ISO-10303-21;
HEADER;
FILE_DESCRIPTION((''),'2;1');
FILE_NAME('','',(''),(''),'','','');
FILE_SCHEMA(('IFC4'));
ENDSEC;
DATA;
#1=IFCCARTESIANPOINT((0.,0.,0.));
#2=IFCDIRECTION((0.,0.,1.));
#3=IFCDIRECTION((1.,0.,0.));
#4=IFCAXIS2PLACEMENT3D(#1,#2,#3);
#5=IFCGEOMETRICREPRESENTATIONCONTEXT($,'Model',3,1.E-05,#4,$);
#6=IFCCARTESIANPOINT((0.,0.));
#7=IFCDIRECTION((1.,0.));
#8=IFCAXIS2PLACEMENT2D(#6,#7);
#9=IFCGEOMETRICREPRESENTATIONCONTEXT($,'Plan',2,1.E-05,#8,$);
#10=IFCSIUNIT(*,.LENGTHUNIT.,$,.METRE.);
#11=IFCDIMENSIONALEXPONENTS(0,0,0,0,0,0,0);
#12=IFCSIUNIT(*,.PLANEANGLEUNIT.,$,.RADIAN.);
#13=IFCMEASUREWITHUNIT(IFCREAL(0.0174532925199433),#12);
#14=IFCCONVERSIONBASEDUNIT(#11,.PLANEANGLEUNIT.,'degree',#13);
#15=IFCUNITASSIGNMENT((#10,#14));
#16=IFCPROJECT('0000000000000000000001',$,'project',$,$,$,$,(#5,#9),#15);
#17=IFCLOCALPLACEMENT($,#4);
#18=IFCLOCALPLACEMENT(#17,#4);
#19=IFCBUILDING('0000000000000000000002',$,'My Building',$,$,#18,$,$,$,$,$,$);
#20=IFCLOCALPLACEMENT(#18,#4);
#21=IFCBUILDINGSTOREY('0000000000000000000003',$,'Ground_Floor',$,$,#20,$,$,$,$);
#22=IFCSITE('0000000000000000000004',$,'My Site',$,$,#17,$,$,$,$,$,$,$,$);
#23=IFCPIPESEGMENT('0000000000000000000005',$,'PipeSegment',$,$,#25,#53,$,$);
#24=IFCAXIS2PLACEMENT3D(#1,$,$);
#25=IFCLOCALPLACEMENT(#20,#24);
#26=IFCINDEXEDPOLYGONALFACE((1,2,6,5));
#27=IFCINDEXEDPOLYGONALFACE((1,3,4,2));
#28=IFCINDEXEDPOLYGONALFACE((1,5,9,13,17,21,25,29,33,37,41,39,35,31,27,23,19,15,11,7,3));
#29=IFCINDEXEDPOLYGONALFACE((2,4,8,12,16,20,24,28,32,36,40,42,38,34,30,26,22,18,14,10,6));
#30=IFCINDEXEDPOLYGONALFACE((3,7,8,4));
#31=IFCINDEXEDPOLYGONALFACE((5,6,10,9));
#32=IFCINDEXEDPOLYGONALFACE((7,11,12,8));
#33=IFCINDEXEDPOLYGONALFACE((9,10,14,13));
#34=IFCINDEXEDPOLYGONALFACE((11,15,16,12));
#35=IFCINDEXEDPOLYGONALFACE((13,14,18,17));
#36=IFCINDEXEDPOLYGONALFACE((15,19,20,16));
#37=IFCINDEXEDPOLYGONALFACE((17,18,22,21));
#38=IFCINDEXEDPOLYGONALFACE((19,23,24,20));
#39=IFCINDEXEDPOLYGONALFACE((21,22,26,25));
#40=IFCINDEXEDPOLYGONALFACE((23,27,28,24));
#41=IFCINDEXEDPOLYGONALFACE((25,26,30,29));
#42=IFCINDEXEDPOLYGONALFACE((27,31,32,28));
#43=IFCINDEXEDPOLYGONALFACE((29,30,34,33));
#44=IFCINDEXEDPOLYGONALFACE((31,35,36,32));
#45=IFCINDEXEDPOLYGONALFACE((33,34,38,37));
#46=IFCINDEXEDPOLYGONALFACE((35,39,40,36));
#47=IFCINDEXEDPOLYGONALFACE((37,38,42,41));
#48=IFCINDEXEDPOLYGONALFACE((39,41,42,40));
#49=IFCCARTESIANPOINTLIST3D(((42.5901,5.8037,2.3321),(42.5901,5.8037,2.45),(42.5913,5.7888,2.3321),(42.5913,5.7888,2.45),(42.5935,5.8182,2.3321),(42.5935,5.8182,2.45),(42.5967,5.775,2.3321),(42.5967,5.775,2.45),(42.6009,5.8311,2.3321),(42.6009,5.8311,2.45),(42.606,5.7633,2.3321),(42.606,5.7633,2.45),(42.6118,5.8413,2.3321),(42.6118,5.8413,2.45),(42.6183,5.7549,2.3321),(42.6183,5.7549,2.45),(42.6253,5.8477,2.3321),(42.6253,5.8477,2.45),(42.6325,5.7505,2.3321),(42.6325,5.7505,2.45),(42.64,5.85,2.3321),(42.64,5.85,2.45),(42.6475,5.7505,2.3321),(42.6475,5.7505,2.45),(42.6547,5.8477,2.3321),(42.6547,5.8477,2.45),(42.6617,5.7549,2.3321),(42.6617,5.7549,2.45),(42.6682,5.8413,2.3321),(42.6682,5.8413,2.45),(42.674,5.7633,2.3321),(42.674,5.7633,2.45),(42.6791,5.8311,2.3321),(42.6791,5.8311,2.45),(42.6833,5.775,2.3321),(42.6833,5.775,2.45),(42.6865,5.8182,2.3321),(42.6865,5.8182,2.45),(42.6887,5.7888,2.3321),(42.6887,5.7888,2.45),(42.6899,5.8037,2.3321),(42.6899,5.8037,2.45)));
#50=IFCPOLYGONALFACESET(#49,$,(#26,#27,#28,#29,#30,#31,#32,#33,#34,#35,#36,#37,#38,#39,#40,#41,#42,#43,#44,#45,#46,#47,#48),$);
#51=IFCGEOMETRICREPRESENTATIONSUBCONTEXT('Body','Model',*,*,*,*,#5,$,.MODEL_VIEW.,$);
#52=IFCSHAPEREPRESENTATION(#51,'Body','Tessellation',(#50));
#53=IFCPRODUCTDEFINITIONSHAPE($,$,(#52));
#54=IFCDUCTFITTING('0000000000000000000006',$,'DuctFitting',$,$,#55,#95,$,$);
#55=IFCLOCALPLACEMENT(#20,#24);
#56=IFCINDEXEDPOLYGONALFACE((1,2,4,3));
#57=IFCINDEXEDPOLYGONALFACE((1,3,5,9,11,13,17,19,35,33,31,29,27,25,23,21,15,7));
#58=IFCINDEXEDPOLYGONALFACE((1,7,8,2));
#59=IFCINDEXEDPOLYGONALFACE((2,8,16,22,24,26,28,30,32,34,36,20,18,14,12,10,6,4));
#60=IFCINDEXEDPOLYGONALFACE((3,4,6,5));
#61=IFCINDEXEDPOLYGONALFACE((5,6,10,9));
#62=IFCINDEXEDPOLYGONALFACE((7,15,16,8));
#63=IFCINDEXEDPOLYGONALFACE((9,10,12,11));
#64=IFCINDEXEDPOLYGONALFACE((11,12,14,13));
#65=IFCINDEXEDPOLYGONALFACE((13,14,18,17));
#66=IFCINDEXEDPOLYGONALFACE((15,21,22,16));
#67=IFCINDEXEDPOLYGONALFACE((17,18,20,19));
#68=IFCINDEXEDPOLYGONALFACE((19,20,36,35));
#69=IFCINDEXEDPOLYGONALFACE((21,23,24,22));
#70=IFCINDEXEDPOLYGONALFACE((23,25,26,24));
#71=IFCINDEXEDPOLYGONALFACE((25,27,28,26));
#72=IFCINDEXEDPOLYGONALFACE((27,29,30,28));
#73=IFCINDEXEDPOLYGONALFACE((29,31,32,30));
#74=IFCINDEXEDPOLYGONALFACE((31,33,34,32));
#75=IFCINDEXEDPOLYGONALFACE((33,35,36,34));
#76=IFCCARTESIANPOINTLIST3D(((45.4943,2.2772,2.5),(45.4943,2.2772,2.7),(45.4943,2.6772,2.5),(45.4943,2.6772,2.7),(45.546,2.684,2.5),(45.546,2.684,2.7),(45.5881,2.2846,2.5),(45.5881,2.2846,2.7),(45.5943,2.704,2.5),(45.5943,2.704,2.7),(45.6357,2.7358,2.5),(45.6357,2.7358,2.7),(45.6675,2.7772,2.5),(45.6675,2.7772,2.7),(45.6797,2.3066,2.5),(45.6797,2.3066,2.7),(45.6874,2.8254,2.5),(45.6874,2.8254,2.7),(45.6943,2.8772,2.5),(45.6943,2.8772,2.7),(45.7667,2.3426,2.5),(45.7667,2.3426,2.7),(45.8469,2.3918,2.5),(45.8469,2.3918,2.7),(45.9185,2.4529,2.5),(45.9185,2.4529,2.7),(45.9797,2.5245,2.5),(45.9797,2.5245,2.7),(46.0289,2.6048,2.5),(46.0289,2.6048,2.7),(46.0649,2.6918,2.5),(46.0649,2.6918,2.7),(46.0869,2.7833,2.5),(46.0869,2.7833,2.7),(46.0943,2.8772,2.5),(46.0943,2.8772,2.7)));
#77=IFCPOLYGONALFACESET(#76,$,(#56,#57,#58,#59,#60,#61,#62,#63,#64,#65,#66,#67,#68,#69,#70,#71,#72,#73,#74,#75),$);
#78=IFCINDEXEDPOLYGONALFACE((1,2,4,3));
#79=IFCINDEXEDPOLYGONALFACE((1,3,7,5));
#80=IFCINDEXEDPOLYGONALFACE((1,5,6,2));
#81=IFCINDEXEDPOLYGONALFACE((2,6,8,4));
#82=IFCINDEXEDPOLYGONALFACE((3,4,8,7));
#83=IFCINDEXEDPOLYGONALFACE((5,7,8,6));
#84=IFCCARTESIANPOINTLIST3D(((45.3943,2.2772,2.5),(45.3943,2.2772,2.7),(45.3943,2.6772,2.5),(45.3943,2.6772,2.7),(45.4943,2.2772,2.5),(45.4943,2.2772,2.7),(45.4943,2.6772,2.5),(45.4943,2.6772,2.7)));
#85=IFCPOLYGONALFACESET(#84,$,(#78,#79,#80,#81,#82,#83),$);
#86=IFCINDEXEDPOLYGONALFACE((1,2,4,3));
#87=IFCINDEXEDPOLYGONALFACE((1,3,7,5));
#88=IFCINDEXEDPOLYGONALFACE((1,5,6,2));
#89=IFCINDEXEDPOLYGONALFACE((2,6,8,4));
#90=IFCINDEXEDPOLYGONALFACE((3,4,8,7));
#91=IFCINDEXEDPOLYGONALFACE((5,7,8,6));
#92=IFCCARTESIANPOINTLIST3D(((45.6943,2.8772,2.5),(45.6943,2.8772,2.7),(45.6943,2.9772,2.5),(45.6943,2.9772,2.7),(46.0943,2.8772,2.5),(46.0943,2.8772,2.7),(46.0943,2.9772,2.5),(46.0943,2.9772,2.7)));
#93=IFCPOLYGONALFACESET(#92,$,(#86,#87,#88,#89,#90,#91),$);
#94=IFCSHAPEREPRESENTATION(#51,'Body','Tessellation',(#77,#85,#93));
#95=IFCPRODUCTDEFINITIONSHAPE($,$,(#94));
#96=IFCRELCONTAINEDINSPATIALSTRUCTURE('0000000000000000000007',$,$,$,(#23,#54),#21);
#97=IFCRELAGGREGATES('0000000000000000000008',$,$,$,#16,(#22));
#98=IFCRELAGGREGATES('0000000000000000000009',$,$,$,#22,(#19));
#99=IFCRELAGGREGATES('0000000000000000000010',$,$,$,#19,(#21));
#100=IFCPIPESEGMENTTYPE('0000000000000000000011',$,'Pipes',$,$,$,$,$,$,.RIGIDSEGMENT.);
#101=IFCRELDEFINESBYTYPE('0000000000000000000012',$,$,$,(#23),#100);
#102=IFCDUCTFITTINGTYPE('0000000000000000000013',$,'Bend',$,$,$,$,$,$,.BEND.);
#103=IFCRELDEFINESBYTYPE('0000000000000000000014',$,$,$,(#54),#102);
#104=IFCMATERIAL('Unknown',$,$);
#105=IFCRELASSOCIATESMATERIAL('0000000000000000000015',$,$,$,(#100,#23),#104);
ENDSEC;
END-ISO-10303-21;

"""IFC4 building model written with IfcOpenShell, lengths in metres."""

from ifc_helpers import new_model, entity, si_unit, converted_unit, frame, origin_with_axes, origin_2d_with_axis, place, context, subcontext, project, spatial, line, arc, indexed_curve, rectangle, circle, outline, extrude, source, transform, mapped, material, material_profile, profile_set, profile_usage, type_object, type_shapes, element, save


model = new_model("IFC4")

# Units and contexts
model_context = context("Model", 3, precision=1e-05, world=origin_with_axes())
plan_context = context("Plan", 2, precision=1e-05, world=origin_2d_with_axis())
body_context = subcontext(model_context, "Body", "Model", "MODEL_VIEW")
ifc_project = project(units=[si_unit("LENGTHUNIT", "METRE"), converted_unit("PLANEANGLEUNIT", "degree", entity("IfcReal", 0.0174532925199433), si_unit("PLANEANGLEUNIT", "RADIAN"), dimensions=[0, 0, 0, 0, 0, 0, 0])], contexts=[model_context, plan_context])

# Site, building, storey
site_placement = place(None, origin_with_axes())
site = spatial("IfcSite", under=ifc_project, at=site_placement, Name="My Site")
building_placement = place(site_placement, origin_with_axes())
building = spatial("IfcBuilding", under=site, at=building_placement, Name="My Building")
storey_placement = place(building_placement, origin_with_axes())
storey = spatial("IfcBuildingStorey", under=building, at=storey_placement, Name="Ground_Floor")

# Shared definitions
ifc_material = material(Name="Unknown")

# Pipe segment
ifc_material_profile_1 = material_profile(ifc_material, circle(Radius=0.05))
ifc_profile_set_1 = profile_set([ifc_material_profile_1])
pipe_segment_type = type_object("IfcPipeSegmentType", Name="Pipes", PredefinedType="RIGIDSEGMENT", material=ifc_profile_set_1)
ifc_profile_usage_1 = profile_usage(ifc_profile_set_1, cardinal=5)
pipe_segment_1_placement = place(storey_placement, frame((42.64, 5.8, 2.45), z_axis=(-0.000001, 0.0, -1.0), x_axis=(0.0, 1.0, 0.0)))
element("IfcPipeSegment", 1, at=pipe_segment_1_placement, inside=storey, type_object=pipe_segment_type, material=ifc_profile_usage_1, Name="PipeSegment", context=body_context, shape_type="SweptSolid", body=[
    extrude(circle(Radius=0.05), origin_with_axes(), (0.0, 0.0, 1.0), 0.1179),
])

# Duct fitting
duct_fitting_type = type_object("IfcDuctFittingType", Name="Bend", PredefinedType="BEND")
shared_shape_1 = source(origin_with_axes(), body_context, "Body", "SweptSolid", [
    extrude(outline(indexed_curve([(0.2, 0.0), (0.2586, -0.1414), (0.4, -0.2), (0.4, -0.6), (-0.0243, -0.4243), (-0.2, 0.0)], segments=[arc(1, 2, 3), line(3, 4), arc(4, 5, 6), line(6, 1)])), frame((0.0, -0.1, -0.1), z_axis=(0.0, -1.0, 0.0), x_axis=(1.0, 0.0, 0.0)), (0.0, 0.0, -1.0), 0.2),
    extrude(rectangle(XDim=0.4, YDim=0.2), origin_with_axes(), (0.0, 0.0, -1.0), 0.1),
    extrude(rectangle(XDim=0.4, YDim=0.2), frame((0.4, 0.0, -0.5), z_axis=(1.0, 0.0, 0.0), x_axis=(0.0, 0.0, 1.0)), (0.0, 0.0, 1.0), 0.1),
])
type_shapes(duct_fitting_type, [shared_shape_1])
duct_fitting_placement = place(storey_placement, frame((45.3943, 2.4772, 2.6), z_axis=(-1.0, 0.0, 0.0), x_axis=(0.0, 1.0, 0.0)))
element("IfcDuctFitting", 2, at=duct_fitting_placement, inside=storey, type_object=duct_fitting_type, Name="DuctFitting", context=body_context, shape_type="MappedRepresentation", body=[
    mapped(shared_shape_1, transform((0.0, 0.0, 0.0), x_axis=(1.0, 0.0, 0.0), y_axis=(0.0, 1.0, 0.0), z_axis=(0.0, 0.0, 1.0), scale=1.0)),
])

save(model, "model.ifc")
